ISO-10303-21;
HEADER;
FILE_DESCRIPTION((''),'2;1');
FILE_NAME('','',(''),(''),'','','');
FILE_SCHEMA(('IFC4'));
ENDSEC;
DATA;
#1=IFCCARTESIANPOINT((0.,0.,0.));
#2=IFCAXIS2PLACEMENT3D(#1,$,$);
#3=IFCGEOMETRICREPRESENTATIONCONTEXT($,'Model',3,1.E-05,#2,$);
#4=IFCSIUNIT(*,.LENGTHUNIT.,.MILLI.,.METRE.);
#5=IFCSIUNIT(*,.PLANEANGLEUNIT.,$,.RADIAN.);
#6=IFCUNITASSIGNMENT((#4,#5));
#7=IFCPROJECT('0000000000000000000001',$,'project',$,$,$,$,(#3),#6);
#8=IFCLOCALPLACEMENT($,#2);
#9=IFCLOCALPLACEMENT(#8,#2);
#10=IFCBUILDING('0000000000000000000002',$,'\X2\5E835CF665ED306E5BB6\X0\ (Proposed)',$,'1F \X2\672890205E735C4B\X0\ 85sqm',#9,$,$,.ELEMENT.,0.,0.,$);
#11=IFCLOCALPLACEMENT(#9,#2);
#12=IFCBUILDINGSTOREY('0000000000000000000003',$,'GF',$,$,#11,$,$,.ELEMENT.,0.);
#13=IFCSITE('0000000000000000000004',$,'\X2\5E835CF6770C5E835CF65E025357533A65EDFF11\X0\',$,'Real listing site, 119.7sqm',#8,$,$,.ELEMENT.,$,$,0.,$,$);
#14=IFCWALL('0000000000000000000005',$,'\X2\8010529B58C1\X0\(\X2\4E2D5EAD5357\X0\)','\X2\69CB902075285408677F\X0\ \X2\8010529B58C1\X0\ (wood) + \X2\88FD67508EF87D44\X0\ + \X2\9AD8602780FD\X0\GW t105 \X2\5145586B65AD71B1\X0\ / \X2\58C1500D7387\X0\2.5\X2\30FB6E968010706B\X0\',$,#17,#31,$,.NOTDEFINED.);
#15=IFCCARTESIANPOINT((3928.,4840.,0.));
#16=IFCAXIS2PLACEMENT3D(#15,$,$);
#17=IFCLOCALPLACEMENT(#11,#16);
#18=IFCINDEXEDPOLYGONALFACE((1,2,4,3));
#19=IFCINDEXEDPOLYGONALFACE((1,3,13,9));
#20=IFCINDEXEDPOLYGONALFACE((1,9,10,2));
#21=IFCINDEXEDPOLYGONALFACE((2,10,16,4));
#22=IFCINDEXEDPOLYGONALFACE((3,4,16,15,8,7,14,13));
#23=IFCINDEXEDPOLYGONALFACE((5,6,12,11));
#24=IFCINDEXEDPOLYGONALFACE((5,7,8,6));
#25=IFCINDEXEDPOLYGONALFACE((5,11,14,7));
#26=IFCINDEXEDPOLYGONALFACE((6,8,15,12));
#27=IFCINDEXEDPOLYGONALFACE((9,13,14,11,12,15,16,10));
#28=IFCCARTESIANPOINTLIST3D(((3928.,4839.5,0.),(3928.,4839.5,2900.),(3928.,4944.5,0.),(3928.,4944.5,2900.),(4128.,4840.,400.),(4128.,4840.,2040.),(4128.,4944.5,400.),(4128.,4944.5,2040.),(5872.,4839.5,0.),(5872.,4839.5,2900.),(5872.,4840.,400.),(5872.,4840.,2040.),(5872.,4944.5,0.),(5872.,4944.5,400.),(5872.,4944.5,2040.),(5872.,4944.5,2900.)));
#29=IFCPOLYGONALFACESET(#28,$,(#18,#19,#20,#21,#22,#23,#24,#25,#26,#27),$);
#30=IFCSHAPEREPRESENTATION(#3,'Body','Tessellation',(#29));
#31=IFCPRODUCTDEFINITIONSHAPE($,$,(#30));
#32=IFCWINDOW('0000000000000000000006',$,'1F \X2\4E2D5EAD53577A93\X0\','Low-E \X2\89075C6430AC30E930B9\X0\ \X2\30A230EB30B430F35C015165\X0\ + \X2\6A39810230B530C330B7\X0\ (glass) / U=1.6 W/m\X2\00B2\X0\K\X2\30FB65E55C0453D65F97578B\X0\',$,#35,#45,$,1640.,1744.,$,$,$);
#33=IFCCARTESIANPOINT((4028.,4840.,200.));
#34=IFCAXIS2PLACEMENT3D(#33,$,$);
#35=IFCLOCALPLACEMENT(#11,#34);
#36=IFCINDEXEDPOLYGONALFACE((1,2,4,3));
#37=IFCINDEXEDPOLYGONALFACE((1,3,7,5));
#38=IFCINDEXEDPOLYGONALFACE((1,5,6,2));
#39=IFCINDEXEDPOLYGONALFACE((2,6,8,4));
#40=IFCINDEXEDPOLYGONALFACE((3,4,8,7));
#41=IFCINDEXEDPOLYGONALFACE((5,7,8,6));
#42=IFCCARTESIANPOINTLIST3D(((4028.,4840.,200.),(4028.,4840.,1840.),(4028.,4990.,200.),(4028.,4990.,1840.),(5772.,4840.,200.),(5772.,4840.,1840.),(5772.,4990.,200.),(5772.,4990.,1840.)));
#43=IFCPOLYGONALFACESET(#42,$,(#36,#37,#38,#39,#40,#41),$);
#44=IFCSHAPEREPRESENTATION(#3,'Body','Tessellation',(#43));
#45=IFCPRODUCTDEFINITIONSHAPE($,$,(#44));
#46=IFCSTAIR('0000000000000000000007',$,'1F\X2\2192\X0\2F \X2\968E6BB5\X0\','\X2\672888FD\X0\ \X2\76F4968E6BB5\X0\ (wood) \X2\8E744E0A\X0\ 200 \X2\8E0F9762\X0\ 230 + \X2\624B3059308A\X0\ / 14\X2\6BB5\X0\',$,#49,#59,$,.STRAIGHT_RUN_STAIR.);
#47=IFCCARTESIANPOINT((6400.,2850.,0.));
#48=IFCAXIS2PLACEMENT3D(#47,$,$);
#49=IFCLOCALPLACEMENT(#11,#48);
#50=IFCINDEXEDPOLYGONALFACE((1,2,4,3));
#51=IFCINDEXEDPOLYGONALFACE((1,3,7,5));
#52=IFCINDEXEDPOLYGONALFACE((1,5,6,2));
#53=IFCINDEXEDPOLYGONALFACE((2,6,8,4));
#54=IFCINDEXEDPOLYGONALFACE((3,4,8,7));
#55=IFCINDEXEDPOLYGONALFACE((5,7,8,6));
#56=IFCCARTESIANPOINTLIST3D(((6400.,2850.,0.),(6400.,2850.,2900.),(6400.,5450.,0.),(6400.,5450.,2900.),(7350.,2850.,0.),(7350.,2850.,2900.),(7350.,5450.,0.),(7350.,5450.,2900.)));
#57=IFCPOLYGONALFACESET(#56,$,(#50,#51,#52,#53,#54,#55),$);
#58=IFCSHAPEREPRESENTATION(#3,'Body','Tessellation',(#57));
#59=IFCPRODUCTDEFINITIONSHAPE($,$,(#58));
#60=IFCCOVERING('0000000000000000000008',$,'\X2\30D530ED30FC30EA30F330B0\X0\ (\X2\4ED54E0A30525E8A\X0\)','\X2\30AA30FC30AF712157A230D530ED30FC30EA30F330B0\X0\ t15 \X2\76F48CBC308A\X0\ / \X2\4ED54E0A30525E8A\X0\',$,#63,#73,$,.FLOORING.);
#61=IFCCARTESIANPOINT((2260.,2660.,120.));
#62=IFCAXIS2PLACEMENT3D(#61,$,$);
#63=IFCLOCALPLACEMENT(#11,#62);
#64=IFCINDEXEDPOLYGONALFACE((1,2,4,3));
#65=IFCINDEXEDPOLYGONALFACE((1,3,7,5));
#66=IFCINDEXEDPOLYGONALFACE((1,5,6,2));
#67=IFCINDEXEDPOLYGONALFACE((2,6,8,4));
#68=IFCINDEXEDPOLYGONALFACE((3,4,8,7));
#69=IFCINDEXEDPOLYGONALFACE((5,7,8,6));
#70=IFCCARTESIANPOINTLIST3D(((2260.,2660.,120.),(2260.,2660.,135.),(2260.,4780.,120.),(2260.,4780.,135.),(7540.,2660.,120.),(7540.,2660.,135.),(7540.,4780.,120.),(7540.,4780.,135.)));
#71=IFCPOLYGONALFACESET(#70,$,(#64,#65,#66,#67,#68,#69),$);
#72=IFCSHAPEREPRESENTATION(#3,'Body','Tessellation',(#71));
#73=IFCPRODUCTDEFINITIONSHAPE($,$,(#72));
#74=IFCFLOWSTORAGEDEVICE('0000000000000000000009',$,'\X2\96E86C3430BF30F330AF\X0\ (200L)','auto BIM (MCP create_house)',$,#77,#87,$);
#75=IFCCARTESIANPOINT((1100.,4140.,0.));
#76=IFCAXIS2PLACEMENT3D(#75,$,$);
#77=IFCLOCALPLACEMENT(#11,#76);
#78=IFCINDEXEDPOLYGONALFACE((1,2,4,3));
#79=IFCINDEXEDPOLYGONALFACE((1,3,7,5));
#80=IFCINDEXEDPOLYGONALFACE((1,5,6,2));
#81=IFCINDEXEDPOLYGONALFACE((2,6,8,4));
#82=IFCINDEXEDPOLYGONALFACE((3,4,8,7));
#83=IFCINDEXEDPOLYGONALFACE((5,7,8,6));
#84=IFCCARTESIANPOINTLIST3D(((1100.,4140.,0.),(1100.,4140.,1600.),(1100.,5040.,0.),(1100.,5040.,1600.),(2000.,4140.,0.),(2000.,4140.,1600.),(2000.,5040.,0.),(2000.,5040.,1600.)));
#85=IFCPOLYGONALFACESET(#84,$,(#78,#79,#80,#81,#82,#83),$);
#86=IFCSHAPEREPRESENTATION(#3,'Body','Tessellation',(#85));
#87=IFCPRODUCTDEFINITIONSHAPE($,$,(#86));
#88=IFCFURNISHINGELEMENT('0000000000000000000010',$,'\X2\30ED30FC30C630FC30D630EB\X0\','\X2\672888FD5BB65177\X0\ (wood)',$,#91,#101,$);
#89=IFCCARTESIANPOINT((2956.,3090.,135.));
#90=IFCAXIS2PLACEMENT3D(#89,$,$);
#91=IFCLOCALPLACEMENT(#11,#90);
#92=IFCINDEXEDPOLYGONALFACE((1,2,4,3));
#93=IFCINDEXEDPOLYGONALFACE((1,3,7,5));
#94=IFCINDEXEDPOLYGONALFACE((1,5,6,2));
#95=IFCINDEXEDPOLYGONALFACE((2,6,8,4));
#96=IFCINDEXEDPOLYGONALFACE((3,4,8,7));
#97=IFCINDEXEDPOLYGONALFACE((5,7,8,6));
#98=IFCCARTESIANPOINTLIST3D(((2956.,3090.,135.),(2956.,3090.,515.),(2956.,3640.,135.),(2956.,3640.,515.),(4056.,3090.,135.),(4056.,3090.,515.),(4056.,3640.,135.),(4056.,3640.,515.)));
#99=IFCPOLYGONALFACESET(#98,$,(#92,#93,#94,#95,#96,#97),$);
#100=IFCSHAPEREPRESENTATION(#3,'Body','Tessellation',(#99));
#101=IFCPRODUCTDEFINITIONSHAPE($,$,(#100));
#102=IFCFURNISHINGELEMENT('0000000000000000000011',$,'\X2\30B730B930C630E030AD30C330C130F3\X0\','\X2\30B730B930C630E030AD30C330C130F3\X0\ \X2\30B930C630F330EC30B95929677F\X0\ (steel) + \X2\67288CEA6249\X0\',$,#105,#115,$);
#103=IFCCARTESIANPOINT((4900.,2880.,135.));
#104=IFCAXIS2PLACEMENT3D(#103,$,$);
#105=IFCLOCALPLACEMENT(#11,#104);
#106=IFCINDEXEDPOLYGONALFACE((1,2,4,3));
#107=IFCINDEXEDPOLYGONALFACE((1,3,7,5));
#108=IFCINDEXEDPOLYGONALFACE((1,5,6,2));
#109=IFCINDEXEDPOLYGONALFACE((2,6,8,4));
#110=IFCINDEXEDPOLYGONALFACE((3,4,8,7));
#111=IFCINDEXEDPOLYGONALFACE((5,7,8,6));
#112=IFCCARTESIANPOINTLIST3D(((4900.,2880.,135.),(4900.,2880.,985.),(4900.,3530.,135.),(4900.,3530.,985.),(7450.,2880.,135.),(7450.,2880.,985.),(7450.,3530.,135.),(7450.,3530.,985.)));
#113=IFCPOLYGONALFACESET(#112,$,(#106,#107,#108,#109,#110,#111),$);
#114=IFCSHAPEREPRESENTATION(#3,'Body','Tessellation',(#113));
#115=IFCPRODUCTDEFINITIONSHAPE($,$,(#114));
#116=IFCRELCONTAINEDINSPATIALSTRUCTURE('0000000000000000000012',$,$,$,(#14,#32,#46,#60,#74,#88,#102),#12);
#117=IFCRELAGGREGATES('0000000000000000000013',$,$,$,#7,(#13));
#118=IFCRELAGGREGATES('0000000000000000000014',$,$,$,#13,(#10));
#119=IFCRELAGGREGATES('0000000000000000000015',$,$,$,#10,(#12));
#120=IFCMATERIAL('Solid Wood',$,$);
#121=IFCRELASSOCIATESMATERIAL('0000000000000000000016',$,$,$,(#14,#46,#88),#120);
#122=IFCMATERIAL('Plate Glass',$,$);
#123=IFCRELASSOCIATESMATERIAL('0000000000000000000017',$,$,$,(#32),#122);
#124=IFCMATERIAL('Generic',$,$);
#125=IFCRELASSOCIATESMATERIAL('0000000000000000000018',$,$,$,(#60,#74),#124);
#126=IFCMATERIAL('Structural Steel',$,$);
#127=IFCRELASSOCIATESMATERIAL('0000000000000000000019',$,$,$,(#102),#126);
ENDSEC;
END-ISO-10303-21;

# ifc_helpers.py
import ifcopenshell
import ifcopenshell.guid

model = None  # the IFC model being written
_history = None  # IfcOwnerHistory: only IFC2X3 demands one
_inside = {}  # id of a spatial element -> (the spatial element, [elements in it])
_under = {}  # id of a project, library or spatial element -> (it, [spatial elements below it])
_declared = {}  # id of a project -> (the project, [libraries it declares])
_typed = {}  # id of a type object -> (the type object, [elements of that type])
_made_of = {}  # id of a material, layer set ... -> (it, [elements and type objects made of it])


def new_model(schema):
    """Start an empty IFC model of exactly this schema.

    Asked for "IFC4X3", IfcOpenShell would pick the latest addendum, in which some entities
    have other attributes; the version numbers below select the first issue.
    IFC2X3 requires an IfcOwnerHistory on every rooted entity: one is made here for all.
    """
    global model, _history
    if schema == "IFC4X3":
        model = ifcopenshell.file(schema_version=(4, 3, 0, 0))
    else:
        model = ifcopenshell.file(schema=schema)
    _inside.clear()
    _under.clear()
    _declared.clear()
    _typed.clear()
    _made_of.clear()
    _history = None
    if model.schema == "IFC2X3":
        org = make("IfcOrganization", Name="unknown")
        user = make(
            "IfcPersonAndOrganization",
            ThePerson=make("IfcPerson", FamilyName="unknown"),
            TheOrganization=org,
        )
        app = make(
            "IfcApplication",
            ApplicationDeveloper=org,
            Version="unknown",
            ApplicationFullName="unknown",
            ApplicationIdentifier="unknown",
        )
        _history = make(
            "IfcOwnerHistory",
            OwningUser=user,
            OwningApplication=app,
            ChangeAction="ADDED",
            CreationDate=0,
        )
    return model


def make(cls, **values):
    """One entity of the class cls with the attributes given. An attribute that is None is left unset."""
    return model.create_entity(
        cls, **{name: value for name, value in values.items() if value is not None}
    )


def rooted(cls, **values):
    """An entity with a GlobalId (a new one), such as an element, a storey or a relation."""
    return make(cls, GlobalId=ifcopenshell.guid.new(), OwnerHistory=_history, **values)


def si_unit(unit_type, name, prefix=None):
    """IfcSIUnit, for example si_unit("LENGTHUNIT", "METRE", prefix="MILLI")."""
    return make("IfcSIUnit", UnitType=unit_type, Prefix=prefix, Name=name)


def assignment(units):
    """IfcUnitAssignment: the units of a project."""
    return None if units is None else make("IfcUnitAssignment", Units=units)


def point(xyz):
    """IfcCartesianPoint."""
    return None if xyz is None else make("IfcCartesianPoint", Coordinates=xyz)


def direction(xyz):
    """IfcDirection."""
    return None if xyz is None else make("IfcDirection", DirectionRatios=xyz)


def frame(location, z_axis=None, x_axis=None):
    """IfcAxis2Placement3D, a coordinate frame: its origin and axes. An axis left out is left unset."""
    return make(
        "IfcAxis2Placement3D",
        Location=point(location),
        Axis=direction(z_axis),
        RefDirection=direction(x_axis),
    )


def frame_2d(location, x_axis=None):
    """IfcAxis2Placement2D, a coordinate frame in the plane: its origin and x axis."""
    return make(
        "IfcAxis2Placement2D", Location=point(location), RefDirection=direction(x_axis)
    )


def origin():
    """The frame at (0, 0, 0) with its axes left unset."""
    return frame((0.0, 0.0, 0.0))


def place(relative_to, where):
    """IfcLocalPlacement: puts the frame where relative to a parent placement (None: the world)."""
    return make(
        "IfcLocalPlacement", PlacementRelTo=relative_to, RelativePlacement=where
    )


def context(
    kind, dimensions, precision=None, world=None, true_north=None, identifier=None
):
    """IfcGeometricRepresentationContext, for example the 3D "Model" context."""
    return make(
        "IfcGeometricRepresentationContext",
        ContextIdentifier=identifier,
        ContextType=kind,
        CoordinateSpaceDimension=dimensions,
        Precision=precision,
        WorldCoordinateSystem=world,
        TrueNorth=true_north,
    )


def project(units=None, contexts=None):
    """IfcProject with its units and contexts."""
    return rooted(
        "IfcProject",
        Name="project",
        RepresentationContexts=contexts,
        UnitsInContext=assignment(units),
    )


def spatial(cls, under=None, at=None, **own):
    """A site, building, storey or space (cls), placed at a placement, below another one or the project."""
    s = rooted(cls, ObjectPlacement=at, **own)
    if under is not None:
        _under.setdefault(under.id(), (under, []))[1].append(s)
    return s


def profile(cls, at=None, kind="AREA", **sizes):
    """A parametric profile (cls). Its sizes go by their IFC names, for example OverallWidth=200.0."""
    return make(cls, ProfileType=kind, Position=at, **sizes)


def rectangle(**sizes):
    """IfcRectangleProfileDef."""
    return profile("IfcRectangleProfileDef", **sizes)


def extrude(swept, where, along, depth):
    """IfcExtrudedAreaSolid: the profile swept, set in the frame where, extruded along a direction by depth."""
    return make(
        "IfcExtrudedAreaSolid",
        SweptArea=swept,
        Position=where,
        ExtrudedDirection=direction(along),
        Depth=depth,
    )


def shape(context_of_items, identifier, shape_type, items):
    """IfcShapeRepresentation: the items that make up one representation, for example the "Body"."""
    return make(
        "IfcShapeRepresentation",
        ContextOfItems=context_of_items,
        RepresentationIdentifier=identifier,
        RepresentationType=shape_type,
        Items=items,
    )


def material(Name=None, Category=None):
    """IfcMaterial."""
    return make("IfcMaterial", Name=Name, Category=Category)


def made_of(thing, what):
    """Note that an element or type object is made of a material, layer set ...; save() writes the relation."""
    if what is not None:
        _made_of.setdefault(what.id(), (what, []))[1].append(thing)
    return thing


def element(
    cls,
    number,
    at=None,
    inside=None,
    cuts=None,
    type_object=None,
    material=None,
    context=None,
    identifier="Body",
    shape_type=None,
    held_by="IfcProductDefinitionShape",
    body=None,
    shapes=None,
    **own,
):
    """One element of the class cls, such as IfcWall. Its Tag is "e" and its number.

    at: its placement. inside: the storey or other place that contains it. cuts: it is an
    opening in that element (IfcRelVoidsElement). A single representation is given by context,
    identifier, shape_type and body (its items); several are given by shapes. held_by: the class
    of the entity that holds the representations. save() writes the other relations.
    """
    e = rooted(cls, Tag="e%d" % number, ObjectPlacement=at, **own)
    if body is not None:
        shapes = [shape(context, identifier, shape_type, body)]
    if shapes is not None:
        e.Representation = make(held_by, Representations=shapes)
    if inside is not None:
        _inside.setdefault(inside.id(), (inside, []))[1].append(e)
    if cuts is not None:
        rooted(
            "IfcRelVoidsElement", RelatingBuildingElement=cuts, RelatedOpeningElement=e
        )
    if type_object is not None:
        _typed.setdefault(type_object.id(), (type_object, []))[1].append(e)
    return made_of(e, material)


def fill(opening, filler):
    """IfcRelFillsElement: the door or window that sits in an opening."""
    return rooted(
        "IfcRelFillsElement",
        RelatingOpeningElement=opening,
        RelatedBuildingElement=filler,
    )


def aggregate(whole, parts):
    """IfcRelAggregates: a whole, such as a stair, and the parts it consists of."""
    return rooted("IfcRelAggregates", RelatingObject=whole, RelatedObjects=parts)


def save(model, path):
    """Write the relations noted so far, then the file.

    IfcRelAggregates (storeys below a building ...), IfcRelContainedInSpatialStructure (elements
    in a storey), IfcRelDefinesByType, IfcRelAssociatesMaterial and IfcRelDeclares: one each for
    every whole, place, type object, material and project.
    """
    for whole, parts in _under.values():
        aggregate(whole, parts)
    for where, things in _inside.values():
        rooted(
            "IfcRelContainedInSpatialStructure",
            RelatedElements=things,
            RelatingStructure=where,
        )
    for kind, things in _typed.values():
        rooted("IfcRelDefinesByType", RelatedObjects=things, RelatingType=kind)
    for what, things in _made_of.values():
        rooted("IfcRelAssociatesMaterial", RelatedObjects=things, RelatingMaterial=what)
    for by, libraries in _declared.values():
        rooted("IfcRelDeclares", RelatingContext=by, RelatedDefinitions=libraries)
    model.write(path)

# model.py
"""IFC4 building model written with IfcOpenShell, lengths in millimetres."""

from ifc_helpers import new_model, si_unit, frame, frame_2d, origin, place, context, project, spatial, rectangle, extrude, material, element, fill, save


model = new_model("IFC4")

# Units and contexts
model_context = context("Model", 3, precision=1e-05, world=origin())
ifc_project = project(units=[si_unit("LENGTHUNIT", "METRE", prefix="MILLI"), si_unit("PLANEANGLEUNIT", "RADIAN")], contexts=[model_context])

# Site, building, storey
site_placement = place(None, origin())
site = spatial("IfcSite", under=ifc_project, at=site_placement, Name="広島県広島市南区旭１", ObjectType="Real listing site, 119.7sqm", CompositionType="ELEMENT", RefElevation=0.0)
building_placement = place(site_placement, origin())
building = spatial("IfcBuilding", under=site, at=building_placement, Name="広島旭の家 (Proposed)", ObjectType="1F 木造平屋 85sqm", CompositionType="ELEMENT", ElevationOfRefHeight=0.0, ElevationOfTerrain=0.0)
storey_placement = place(building_placement, origin())
storey = spatial("IfcBuildingStorey", under=building, at=storey_placement, Name="GF", CompositionType="ELEMENT", Elevation=0.0)

# Shared definitions
ifc_material_1 = material(Name="Solid Wood")

# Shared definitions
ifc_material_2 = material(Name="Plate Glass")

# Wall, opening, window
wall_1_placement = place(storey_placement, frame((3928.0, 4840.0, 0.0)))
wall_1 = element("IfcWall", 1, at=wall_1_placement, inside=storey, material=ifc_material_1, Name="耐力壁(中庭南)", Description="構造用合板 耐力壁 (wood) + 製材軸組 + 高性能GW t105 充填断熱 / 壁倍率2.5・準耐火", PredefinedType="NOTDEFINED", context=model_context, shape_type="SweptSolid", body=[
    extrude(rectangle(XDim=1944.0, YDim=105.0, at=frame_2d((972.0, 52.0))), frame((3928.0, 4840.0, 0.0)), (0.0, 0.0, 1.0), 2900.0),
])
opening_1_placement = place(storey_placement, frame((4028.0, 4840.0, 200.0)))
opening_1 = element("IfcOpeningElement", 2, at=opening_1_placement, cuts=wall_1, PredefinedType="NOTDEFINED", context=model_context, shape_type="SweptSolid", body=[
    extrude(rectangle(XDim=1744.0, YDim=150.0, at=frame_2d((872.0, 75.0))), frame((4028.0, 4840.0, 200.0)), (0.0, 0.0, 1.0), 1640.0),
])
window_1_placement = place(storey_placement, frame((4028.0, 4840.0, 200.0)))
window_1 = element("IfcWindow", 3, at=window_1_placement, inside=storey, material=ifc_material_2, Name="1F 中庭南窓", Description="Low-E 複層ガラス アルゴン封入 + 樹脂サッシ (glass) / U=1.6 W/m²K・日射取得型", OverallHeight=1640.0, OverallWidth=1744.0, context=model_context, shape_type="SweptSolid", body=[
    extrude(rectangle(XDim=1744.0, YDim=150.0, at=frame_2d((872.0, 75.0))), frame((4028.0, 4840.0, 200.0)), (0.0, 0.0, 1.0), 1640.0),
])
fill(opening_1, window_1)

# Stair
stair_placement = place(storey_placement, frame((6400.0, 2850.0, 0.0)))
element("IfcStair", 4, at=stair_placement, inside=storey, material=ifc_material_1, Name="1F→2F 階段", Description="木製 直階段 (wood) 蹴上 200 踏面 230 + 手すり / 14段", PredefinedType="STRAIGHT_RUN_STAIR", context=model_context, shape_type="SweptSolid", body=[
    extrude(rectangle(XDim=950.0, YDim=2600.0, at=frame_2d((475.0, 1300.0))), frame((6400.0, 2850.0, 0.0)), (0.0, 0.0, 1.0), 2900.0),
])

# Covering
ifc_material_3 = material(Name="Generic")
covering_placement = place(storey_placement, frame((2260.0, 2660.0, 120.0)))
element("IfcCovering", 5, at=covering_placement, inside=storey, material=ifc_material_3, Name="フローリング (仕上げ床)", Description="オーク無垢フローリング t15 直貼り / 仕上げ床", PredefinedType="FLOORING", context=model_context, shape_type="SweptSolid", body=[
    extrude(rectangle(XDim=5280.0, YDim=2120.0, at=frame_2d((2640.0, 1060.0))), frame((2260.0, 2660.0, 120.0)), (0.0, 0.0, 1.0), 15.0),
])

# Flow storage device
flow_storage_device_placement = place(storey_placement, frame((1100.0, 4140.0, 0.0)))
element("IfcFlowStorageDevice", 6, at=flow_storage_device_placement, inside=storey, material=ifc_material_3, Name="雨水タンク (200L)", Description="auto BIM (MCP create_house)", context=model_context, shape_type="SweptSolid", body=[
    extrude(rectangle(XDim=900.0, YDim=900.0, at=frame_2d((450.0, 450.0))), frame((1100.0, 4140.0, 0.0)), (0.0, 0.0, 1.0), 1600.0),
])

# Furnishing elements
furnishing_1_placement = place(storey_placement, frame((2956.0, 3090.0, 135.0)))
element("IfcFurnishingElement", 7, at=furnishing_1_placement, inside=storey, material=ifc_material_1, Name="ローテーブル", Description="木製家具 (wood)", context=model_context, shape_type="SweptSolid", body=[
    extrude(rectangle(XDim=1100.0, YDim=550.0, at=frame_2d((550.0, 275.0))), frame((2956.0, 3090.0, 135.0)), (0.0, 0.0, 1.0), 380.0),
])
ifc_material_4 = material(Name="Structural Steel")
furnishing_2_placement = place(storey_placement, frame((4900.0, 2880.0, 135.0)))
element("IfcFurnishingElement", 8, at=furnishing_2_placement, inside=storey, material=ifc_material_4, Name="システムキッチン", Description="システムキッチン ステンレス天板 (steel) + 木質扉", context=model_context, shape_type="SweptSolid", body=[
    extrude(rectangle(XDim=2550.0, YDim=650.0, at=frame_2d((1275.0, 325.0))), frame((4900.0, 2880.0, 135.0)), (0.0, 0.0, 1.0), 850.0),
])

save(model, "model.ifc")
